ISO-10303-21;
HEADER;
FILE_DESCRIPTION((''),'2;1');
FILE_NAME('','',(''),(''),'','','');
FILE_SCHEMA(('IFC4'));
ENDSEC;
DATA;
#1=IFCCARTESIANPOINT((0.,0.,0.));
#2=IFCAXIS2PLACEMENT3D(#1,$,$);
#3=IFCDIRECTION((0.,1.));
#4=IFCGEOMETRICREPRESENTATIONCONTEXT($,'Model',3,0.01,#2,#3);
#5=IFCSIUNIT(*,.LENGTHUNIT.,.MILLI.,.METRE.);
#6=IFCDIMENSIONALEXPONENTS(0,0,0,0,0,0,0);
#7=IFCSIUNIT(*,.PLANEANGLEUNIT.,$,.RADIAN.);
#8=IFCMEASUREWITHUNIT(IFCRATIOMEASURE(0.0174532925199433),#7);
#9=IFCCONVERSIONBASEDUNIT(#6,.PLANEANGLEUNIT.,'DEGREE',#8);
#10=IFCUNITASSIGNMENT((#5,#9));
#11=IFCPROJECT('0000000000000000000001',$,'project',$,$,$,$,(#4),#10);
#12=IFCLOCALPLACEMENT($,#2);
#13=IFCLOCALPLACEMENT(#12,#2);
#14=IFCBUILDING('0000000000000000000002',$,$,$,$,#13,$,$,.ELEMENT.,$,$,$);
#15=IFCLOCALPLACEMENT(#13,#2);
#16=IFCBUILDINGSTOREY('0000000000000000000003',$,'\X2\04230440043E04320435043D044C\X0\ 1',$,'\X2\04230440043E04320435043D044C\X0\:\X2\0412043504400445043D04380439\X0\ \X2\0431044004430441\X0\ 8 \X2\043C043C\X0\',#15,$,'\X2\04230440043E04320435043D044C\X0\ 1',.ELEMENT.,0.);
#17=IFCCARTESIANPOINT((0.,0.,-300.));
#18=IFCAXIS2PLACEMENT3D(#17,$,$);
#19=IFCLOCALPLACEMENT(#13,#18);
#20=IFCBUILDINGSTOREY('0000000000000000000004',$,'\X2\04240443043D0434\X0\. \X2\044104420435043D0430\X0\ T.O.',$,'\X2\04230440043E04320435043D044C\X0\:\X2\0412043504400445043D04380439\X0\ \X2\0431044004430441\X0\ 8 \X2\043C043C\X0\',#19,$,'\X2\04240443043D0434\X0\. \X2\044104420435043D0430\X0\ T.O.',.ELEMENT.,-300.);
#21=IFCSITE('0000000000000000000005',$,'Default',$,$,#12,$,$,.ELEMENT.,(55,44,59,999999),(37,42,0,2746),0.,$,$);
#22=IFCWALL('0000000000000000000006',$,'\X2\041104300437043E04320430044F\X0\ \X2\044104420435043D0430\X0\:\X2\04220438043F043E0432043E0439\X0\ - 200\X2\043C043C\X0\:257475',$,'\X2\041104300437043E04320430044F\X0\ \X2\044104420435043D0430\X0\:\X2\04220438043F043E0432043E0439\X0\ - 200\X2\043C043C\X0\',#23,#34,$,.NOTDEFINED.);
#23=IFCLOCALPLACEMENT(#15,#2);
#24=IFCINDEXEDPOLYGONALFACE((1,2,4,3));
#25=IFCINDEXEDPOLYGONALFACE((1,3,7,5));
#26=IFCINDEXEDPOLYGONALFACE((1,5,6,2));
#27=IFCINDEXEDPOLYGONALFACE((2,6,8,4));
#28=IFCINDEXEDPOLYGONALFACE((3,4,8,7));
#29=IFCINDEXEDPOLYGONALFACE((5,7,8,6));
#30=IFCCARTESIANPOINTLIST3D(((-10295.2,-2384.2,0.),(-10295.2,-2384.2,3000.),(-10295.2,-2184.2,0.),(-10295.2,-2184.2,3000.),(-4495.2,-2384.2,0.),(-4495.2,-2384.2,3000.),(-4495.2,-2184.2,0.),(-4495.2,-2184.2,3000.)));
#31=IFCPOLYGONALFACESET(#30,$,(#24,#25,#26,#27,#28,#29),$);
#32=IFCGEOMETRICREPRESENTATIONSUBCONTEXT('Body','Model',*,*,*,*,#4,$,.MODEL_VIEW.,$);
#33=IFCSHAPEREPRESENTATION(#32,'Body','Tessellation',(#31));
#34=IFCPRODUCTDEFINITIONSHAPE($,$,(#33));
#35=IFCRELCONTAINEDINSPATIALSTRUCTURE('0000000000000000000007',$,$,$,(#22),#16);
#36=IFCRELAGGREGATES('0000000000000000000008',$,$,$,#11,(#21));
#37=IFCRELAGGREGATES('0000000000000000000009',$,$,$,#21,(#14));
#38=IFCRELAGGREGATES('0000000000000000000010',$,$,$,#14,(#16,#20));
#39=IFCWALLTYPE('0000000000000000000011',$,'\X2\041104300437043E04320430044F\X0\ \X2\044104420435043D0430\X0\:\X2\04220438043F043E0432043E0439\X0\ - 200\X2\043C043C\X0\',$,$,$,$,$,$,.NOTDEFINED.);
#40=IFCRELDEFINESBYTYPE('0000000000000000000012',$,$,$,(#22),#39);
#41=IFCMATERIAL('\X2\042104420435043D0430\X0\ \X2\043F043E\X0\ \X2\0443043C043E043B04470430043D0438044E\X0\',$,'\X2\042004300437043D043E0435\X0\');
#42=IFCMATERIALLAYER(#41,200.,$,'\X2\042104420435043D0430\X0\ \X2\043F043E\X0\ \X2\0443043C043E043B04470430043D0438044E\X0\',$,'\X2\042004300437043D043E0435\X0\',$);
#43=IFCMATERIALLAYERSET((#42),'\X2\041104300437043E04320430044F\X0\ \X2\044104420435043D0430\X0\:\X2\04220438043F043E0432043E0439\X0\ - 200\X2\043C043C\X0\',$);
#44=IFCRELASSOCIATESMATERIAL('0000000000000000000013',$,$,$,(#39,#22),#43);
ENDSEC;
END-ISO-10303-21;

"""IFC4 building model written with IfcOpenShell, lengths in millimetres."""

from ifc_helpers import new_model, entity, si_unit, converted_unit, direction, frame, frame_2d, origin, place, context, subcontext, project, spatial, rectangle, extrude, material, layer, layer_set, layer_usage, type_object, element, save


model = new_model("IFC4")

# Units and contexts
model_context = context("Model", 3, precision=0.01, world=origin(), true_north=direction((0.0, 1.0)))
body_context = subcontext(model_context, "Body", "Model", "MODEL_VIEW")
ifc_project = project(units=[si_unit("LENGTHUNIT", "METRE", prefix="MILLI"), converted_unit("PLANEANGLEUNIT", "DEGREE", entity("IfcRatioMeasure", 0.0174532925199433), si_unit("PLANEANGLEUNIT", "RADIAN"), dimensions=[0, 0, 0, 0, 0, 0, 0])], contexts=[model_context])

# Site, building, storey
site_placement = place(None, origin())
site = spatial("IfcSite", under=ifc_project, at=site_placement, Name="Default", CompositionType="ELEMENT", RefLatitude=(55, 44, 59, 999999), RefLongitude=(37, 42, 0, 2746), RefElevation=0.0)
building_placement = place(site_placement, origin())
building = spatial("IfcBuilding", under=site, at=building_placement, CompositionType="ELEMENT")
storey_1_placement = place(building_placement, origin())
storey_1 = spatial("IfcBuildingStorey", under=building, at=storey_1_placement, Name="Уровень 1", ObjectType="Уровень:Верхний брус 8 мм", LongName="Уровень 1", CompositionType="ELEMENT", Elevation=0.0)

# Shared definitions
ifc_material_1 = material(Name="Стена по умолчанию", Category="Разное")
ifc_layer = layer(ifc_material_1, 200.0, Name="Стена по умолчанию", Category="Разное")
ifc_layer_set = layer_set([ifc_layer], Name="Базовая стена:Типовой - 200мм")
wall_type = type_object("IfcWallType", Name="Базовая стена:Типовой - 200мм", PredefinedType="NOTDEFINED", material=ifc_layer_set)

# Shared definitions
storey_2_placement = place(building_placement, frame((0.0, 0.0, -300.0)))
storey_2 = spatial("IfcBuildingStorey", under=building, at=storey_2_placement, Name="Фунд. стена T.O.", ObjectType="Уровень:Верхний брус 8 мм", LongName="Фунд. стена T.O.", CompositionType="ELEMENT", Elevation=-300.0)

# Wall
ifc_layer_usage_1 = layer_usage(ifc_layer_set, "AXIS2", "NEGATIVE", 100.0)
wall_1_placement = place(storey_1_placement, frame((-10295.2, -2284.2, 0.0)))
element("IfcWall", 1, at=wall_1_placement, inside=storey_1, type_object=wall_type, material=ifc_layer_usage_1, Name="Базовая стена:Типовой - 200мм:257475", ObjectType="Базовая стена:Типовой - 200мм", PredefinedType="NOTDEFINED", context=body_context, shape_type="SweptSolid", body=[
    extrude(rectangle(XDim=5800.0, YDim=200.0, at=frame_2d((2900.0, 0.0), x_axis=(-1.0, 0.0))), origin(), (0.0, 0.0, 1.0), 3000.0),
])

save(model, "model.ifc")
